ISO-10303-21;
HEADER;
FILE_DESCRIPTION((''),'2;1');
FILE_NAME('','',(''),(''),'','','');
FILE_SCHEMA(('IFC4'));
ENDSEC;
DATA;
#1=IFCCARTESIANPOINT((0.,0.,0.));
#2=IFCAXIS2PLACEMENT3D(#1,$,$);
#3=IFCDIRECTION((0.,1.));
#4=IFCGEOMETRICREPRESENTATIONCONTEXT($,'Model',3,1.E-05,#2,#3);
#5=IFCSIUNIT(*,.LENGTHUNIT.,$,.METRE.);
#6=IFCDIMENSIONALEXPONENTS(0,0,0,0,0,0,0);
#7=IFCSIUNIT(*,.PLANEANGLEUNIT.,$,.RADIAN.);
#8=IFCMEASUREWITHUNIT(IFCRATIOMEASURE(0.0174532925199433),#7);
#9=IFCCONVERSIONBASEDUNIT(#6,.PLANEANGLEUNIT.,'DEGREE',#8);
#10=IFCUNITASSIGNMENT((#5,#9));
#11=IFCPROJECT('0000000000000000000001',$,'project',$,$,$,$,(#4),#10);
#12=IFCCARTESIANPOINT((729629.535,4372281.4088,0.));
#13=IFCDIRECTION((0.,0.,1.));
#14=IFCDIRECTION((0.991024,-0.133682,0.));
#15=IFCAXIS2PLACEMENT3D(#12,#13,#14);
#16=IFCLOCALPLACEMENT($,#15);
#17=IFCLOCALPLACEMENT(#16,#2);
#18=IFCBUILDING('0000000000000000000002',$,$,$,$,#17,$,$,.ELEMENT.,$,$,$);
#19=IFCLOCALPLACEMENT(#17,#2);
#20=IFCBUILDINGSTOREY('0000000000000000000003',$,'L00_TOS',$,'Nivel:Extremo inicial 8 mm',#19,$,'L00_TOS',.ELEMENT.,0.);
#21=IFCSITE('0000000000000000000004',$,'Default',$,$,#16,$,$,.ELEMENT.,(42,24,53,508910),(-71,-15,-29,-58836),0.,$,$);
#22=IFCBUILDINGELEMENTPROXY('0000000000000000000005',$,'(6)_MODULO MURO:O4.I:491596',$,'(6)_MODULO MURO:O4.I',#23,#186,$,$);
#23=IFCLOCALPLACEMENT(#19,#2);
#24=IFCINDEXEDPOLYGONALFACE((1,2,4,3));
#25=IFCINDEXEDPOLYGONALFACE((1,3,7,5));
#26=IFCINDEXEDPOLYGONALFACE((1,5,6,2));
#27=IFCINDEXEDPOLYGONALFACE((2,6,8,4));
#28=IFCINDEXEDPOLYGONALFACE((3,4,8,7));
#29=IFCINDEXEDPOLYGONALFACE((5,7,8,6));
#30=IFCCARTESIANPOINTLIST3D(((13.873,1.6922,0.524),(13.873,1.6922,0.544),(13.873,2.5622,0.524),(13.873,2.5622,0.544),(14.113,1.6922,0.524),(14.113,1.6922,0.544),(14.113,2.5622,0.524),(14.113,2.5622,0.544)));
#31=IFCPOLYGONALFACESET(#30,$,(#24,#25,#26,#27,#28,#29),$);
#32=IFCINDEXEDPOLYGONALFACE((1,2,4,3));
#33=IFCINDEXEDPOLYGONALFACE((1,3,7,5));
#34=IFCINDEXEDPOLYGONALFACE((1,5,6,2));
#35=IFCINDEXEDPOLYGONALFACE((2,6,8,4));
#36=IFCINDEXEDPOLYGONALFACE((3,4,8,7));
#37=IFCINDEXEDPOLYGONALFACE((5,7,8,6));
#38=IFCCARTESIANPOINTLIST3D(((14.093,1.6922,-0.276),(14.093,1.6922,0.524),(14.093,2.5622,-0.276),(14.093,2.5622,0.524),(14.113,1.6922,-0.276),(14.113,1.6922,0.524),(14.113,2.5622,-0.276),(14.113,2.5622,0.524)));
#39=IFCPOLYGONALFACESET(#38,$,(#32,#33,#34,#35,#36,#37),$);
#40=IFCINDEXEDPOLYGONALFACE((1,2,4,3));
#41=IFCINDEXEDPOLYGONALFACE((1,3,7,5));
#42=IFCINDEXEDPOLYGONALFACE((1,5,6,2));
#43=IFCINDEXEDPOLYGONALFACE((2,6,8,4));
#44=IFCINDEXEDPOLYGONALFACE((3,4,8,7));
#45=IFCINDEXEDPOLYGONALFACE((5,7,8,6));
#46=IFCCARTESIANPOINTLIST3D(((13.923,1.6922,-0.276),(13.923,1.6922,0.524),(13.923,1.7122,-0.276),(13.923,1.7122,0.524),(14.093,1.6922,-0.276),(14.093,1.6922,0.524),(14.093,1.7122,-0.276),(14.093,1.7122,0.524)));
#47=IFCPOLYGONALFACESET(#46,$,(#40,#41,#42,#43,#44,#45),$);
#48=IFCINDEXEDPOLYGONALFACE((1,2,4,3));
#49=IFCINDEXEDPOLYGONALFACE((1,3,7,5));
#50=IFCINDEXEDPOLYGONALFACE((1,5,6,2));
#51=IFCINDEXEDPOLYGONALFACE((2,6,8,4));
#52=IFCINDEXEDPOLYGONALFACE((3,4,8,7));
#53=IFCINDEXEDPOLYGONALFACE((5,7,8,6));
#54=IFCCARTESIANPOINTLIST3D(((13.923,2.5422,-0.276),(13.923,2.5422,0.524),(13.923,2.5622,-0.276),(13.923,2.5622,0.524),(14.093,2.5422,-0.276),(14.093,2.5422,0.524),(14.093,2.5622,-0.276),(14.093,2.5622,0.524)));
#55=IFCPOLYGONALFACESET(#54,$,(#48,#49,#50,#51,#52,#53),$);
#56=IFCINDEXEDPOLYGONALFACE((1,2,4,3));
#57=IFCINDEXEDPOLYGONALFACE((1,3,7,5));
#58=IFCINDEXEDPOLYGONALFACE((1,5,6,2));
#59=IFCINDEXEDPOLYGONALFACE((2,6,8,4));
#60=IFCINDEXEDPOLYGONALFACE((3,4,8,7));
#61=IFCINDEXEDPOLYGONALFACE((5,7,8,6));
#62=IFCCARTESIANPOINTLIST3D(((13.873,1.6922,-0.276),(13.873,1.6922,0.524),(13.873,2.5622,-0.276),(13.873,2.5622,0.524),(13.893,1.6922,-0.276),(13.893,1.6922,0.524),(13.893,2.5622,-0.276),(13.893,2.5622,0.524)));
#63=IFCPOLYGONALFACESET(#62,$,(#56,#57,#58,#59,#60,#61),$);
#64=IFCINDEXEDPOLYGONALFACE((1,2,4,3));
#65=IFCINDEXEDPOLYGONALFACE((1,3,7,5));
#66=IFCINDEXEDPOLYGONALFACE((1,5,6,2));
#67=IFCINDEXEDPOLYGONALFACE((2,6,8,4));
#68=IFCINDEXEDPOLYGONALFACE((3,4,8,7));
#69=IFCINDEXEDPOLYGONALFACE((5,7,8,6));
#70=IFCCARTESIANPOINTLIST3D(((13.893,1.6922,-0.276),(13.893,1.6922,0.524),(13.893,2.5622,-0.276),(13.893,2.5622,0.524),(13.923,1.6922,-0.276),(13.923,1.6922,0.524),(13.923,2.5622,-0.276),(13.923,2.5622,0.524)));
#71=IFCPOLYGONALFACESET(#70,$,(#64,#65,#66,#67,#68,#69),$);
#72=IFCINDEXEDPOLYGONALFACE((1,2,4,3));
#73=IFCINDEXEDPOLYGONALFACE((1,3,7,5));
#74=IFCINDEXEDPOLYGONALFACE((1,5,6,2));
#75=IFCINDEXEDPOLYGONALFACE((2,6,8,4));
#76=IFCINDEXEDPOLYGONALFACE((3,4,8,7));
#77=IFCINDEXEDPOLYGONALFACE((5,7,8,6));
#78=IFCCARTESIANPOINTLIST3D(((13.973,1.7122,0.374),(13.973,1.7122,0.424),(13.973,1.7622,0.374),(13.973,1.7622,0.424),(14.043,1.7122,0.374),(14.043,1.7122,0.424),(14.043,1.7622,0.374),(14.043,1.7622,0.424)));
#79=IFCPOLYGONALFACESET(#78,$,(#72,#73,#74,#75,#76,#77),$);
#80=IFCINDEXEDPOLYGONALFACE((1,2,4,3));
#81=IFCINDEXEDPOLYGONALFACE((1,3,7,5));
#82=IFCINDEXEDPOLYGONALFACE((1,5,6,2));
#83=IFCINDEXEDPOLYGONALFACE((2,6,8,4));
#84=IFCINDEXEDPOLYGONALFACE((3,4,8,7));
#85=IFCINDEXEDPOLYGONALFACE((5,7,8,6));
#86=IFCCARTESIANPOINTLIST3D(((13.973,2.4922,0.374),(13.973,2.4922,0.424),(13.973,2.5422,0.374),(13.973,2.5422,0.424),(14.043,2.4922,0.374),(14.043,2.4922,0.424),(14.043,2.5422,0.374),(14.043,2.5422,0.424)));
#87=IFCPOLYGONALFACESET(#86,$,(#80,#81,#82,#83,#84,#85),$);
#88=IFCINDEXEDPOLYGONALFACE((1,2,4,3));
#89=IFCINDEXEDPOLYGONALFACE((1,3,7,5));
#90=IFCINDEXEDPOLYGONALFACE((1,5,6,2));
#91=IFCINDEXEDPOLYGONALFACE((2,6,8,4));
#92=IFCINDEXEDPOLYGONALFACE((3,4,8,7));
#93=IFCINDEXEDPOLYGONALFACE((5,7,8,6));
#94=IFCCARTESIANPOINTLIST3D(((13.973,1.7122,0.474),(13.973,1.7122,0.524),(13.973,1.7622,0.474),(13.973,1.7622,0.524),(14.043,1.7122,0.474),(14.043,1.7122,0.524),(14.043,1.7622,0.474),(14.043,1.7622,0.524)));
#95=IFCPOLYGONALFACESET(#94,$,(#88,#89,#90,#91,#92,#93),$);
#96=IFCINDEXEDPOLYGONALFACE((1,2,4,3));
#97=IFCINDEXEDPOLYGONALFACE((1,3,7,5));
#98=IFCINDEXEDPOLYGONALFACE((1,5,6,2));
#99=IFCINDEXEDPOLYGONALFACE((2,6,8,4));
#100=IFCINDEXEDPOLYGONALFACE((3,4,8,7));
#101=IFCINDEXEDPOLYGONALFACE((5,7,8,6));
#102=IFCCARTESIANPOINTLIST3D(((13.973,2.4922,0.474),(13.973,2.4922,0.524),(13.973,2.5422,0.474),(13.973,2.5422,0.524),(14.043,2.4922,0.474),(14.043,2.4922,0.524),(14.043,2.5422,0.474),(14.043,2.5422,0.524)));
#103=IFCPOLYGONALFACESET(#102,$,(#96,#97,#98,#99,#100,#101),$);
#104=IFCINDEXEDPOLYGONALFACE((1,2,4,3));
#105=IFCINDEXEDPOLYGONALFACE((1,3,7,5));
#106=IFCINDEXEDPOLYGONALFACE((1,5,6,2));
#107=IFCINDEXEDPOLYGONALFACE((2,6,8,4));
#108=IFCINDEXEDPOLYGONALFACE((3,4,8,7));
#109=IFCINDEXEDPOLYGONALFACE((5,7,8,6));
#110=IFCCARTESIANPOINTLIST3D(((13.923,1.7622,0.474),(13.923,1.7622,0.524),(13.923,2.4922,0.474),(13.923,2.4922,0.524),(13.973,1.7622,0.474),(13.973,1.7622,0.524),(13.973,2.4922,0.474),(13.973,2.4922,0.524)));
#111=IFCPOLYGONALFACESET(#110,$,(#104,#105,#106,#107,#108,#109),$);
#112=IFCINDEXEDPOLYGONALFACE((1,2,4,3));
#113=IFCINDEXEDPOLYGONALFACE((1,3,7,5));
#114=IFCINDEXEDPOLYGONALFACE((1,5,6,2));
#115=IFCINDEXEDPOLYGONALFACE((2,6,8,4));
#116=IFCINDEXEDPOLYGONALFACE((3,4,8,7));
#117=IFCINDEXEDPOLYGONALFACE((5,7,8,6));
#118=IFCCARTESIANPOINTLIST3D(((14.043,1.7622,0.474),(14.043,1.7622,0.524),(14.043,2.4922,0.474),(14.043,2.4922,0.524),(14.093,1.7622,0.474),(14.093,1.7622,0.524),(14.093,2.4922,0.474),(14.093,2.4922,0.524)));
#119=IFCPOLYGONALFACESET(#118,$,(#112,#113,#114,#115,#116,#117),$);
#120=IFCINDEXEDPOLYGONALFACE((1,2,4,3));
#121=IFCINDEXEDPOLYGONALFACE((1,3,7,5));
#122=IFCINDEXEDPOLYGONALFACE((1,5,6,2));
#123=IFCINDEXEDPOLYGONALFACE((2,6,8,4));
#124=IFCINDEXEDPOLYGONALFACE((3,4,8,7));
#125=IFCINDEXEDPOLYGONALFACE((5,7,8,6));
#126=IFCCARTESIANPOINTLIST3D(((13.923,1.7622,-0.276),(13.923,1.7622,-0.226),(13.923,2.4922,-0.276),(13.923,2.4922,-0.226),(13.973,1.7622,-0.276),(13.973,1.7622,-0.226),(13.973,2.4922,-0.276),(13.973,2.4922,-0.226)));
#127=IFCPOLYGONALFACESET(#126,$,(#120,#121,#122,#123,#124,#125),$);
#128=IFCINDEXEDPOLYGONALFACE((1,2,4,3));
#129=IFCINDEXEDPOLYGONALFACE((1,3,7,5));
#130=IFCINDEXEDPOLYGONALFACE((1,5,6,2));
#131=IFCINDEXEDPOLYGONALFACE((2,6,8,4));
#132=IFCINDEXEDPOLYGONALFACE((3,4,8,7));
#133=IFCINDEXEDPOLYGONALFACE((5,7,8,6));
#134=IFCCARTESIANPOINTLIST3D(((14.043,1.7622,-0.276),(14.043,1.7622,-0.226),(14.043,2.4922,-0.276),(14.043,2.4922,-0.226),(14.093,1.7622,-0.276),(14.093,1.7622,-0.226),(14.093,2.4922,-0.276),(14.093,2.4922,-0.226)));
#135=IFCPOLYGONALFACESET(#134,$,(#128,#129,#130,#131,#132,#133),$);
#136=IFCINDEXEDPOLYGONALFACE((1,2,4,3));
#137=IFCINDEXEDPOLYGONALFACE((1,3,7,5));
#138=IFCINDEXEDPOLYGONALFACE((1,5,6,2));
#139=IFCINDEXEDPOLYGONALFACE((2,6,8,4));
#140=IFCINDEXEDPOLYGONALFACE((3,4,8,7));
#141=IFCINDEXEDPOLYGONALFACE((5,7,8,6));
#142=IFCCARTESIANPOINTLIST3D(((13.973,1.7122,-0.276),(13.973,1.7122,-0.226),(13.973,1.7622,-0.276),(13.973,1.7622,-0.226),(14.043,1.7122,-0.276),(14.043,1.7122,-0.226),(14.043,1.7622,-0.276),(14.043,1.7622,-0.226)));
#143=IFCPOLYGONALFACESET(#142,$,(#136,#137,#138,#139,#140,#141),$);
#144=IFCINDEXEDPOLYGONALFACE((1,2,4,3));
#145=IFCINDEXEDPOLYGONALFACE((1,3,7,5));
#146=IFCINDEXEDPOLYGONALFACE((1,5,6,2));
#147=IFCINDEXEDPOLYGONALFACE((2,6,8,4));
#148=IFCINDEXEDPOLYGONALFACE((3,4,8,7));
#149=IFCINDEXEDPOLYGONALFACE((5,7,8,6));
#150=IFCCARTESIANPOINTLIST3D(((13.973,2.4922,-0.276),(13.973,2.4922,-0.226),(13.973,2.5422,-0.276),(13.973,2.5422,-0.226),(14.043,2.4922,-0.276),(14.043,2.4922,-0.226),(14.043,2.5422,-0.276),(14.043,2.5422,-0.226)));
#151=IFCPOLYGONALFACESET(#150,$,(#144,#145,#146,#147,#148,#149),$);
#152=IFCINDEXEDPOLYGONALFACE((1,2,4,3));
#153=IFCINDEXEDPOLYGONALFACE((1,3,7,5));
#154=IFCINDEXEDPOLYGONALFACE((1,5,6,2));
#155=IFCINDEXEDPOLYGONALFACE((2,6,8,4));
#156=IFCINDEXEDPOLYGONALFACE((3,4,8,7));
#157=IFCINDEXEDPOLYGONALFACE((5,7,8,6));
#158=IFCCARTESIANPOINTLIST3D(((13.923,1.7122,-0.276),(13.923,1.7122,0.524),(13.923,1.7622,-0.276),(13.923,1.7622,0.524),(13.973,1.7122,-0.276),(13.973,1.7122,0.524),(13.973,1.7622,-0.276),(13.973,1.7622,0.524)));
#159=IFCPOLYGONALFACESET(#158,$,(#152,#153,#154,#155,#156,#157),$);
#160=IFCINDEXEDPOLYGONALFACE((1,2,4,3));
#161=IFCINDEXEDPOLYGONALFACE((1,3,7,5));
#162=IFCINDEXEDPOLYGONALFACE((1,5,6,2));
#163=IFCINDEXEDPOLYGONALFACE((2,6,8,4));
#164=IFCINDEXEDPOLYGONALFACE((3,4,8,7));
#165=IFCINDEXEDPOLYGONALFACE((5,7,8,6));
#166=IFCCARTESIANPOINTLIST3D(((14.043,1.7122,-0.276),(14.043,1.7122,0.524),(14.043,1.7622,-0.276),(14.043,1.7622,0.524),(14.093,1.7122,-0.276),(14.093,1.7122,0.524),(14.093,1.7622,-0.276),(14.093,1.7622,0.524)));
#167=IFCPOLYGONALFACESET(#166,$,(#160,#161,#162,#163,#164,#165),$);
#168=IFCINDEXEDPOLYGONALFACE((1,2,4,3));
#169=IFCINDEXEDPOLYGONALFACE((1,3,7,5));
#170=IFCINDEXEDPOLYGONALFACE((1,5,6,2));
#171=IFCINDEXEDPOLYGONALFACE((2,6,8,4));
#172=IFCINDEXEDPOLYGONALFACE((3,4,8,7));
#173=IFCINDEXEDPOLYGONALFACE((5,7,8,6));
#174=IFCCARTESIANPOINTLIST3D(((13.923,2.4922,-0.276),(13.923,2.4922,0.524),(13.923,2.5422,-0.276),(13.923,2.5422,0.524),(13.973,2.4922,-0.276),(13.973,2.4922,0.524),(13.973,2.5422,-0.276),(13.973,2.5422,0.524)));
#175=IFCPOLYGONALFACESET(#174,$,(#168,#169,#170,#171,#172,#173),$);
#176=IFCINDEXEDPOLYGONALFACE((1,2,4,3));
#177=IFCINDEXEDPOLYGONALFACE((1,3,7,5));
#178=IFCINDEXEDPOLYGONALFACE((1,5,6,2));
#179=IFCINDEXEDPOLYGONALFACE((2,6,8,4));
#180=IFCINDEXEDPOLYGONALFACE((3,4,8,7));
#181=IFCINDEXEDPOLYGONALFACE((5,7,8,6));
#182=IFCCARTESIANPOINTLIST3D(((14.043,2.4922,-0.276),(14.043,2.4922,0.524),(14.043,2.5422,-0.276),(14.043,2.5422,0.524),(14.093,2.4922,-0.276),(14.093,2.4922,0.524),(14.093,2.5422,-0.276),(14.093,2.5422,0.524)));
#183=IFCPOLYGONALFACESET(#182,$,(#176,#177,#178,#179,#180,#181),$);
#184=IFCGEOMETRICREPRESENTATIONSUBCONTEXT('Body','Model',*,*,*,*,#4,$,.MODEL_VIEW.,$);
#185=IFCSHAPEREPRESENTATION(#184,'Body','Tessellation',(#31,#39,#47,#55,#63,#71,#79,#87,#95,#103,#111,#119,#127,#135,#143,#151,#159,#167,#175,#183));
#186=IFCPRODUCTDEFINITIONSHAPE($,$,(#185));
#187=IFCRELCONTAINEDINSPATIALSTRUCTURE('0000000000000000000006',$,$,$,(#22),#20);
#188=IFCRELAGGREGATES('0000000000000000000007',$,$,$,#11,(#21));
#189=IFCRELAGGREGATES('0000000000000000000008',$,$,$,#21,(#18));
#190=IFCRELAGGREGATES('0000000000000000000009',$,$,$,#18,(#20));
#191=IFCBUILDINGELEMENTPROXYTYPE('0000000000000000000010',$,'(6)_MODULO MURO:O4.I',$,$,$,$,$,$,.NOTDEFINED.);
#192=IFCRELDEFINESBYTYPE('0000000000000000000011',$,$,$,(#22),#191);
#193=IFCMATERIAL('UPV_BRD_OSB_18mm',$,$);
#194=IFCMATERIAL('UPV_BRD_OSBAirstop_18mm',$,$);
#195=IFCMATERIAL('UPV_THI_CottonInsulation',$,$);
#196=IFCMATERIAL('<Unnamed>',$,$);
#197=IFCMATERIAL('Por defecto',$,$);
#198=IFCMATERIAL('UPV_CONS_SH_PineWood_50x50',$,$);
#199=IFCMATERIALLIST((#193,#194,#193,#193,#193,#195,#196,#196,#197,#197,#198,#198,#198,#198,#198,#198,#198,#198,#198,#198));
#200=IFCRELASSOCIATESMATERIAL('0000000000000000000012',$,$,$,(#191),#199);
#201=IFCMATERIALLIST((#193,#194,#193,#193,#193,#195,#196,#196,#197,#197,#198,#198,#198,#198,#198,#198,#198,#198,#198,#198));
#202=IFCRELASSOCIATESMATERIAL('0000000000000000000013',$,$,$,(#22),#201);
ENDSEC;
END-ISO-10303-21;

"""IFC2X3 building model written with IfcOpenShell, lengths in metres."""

from ifc_helpers import new_model, entity, si_unit, converted_unit, direction, frame, frame_2d, origin, origin_2d_with_axis, place, context, subcontext, project, spatial, rectangle, extrude, source, transform, mapped, material, material_list, type_object, type_shapes, element, save


model = new_model("IFC2X3")

# Units and contexts
model_context = context("Model", 3, precision=1e-05, world=origin(), true_north=direction((0.0, 1.0)))
body_context = subcontext(model_context, "Body", "Model", "MODEL_VIEW")
ifc_project = project(units=[si_unit("LENGTHUNIT", "METRE"), converted_unit("PLANEANGLEUNIT", "DEGREE", entity("IfcRatioMeasure", 0.0174532925199433), si_unit("PLANEANGLEUNIT", "RADIAN"), dimensions=[0, 0, 0, 0, 0, 0, 0])], contexts=[model_context])

# Site, building, storey
site_placement = place(None, frame((729629.535, 4372281.4088, 0.0), z_axis=(0.0, 0.0, 1.0), x_axis=(0.991024, -0.133682, 0.0)))
site = spatial("IfcSite", under=ifc_project, at=site_placement, Name="Default", CompositionType="ELEMENT", RefLatitude=(42, 24, 53, 508910), RefLongitude=(-71, -15, -29, -58836), RefElevation=0.0)
building_placement = place(site_placement, origin())
building = spatial("IfcBuilding", under=site, at=building_placement, CompositionType="ELEMENT")
storey_placement = place(building_placement, origin())
storey = spatial("IfcBuildingStorey", under=building, at=storey_placement, Name="L00_TOS", ObjectType="Nivel:Extremo inicial 8 mm", LongName="L00_TOS", CompositionType="ELEMENT", Elevation=0.0)

# Building element proxy
ifc_material_1 = material(Name="UPV_BRD_OSBAirstop_18mm")
ifc_material_2 = material(Name="UPV_BRD_OSB_18mm")
ifc_material_3 = material(Name="UPV_THI_CottonInsulation")
ifc_material_4 = material(Name="<Unnamed>")
ifc_material_5 = material(Name="UPV_CONS_SH_PineWood_50x50")
ifc_material_6 = material(Name="Por defecto")
ifc_material_list_1 = material_list([ifc_material_2, ifc_material_1, ifc_material_2, ifc_material_2, ifc_material_2, ifc_material_3, ifc_material_4, ifc_material_4, ifc_material_6, ifc_material_6, ifc_material_5, ifc_material_5, ifc_material_5, ifc_material_5, ifc_material_5, ifc_material_5, ifc_material_5, ifc_material_5, ifc_material_5, ifc_material_5])
ifc_material_list_2 = material_list([ifc_material_2, ifc_material_1, ifc_material_2, ifc_material_2, ifc_material_2, ifc_material_3, ifc_material_4, ifc_material_4, ifc_material_6, ifc_material_6, ifc_material_5, ifc_material_5, ifc_material_5, ifc_material_5, ifc_material_5, ifc_material_5, ifc_material_5, ifc_material_5, ifc_material_5, ifc_material_5])
building_element_proxy_type_1 = type_object("IfcBuildingElementProxyType", Name="(6)_MODULO MURO:O4.I", PredefinedType="NOTDEFINED", material=ifc_material_list_2)
shared_shape_1 = source(origin(), body_context, "Body", "SweptSolid", [
    extrude(rectangle(XDim=0.87, YDim=0.24, at=origin_2d_with_axis()), frame((0.0, 0.015, 0.8), z_axis=(0.0, 0.0, 1.0), x_axis=(-1.0, 0.0, 0.0)), (0.0, 0.0, 1.0), 0.02),
    extrude(rectangle(XDim=0.87, YDim=0.02, at=origin_2d_with_axis()), frame((0.0, -0.095, 0.0)), (0.0, 0.0, 1.0), 0.8),
    extrude(rectangle(XDim=0.17, YDim=0.02, at=frame_2d((0.0, 0.0), x_axis=(1.0, 0.0))), frame((-0.425, 0.0, 0.0), z_axis=(0.0, 0.0, 1.0), x_axis=(0.0, -1.0, 0.0)), (0.0, 0.0, 1.0), 0.8),
    extrude(rectangle(XDim=0.17, YDim=0.02, at=origin_2d_with_axis()), frame((0.425, 0.0, 0.0), z_axis=(0.0, 0.0, 1.0), x_axis=(0.0, -1.0, 0.0)), (0.0, 0.0, 1.0), 0.8),
    extrude(rectangle(XDim=0.87, YDim=0.02, at=origin_2d_with_axis()), frame((0.0, 0.125, 0.0), z_axis=(0.0, 0.0, 1.0), x_axis=(-1.0, 0.0, 0.0)), (0.0, 0.0, 1.0), 0.8),
    extrude(rectangle(XDim=0.87, YDim=0.03, at=origin_2d_with_axis()), frame((0.0, 0.1, 0.0), z_axis=(0.0, 0.0, 1.0), x_axis=(-1.0, 0.0, 0.0)), (0.0, 0.0, 1.0), 0.8),
    extrude(rectangle(XDim=0.07, YDim=0.05, at=origin_2d_with_axis()), frame((-0.39, 0.0, 0.65), z_axis=(0.0, 0.0, 1.0), x_axis=(0.0, 1.0, 0.0)), (0.0, 0.0, 1.0), 0.05),
    extrude(rectangle(XDim=0.07, YDim=0.05, at=origin_2d_with_axis()), frame((0.39, 0.0, 0.65), z_axis=(0.0, 0.0, 1.0), x_axis=(0.0, 1.0, 0.0)), (0.0, 0.0, 1.0), 0.05),
    extrude(rectangle(XDim=0.07, YDim=0.05, at=origin_2d_with_axis()), frame((-0.39, 0.0, 0.75), z_axis=(0.0, 0.0, 1.0), x_axis=(0.0, -1.0, 0.0)), (0.0, 0.0, 1.0), 0.05),
    extrude(rectangle(XDim=0.07, YDim=0.05, at=frame_2d((0.0, 0.0), x_axis=(1.0, 0.0))), frame((0.39, 0.0, 0.75), z_axis=(0.0, 0.0, 1.0), x_axis=(0.0, -1.0, 0.0)), (0.0, 0.0, 1.0), 0.05),
    extrude(rectangle(XDim=0.73, YDim=0.05, at=origin_2d_with_axis()), frame((0.0, 0.06, 0.75), z_axis=(0.0, 0.0, 1.0), x_axis=(-1.0, 0.0, 0.0)), (0.0, 0.0, 1.0), 0.05),
    extrude(rectangle(XDim=0.05, YDim=0.73, at=origin_2d_with_axis()), frame((0.0, -0.06, 0.75), z_axis=(0.0, 0.0, 1.0), x_axis=(0.0, -1.0, 0.0)), (0.0, 0.0, 1.0), 0.05),
    extrude(rectangle(XDim=0.05, YDim=0.73, at=origin_2d_with_axis()), frame((0.0, 0.06, 0.0), z_axis=(0.0, 0.0, 1.0), x_axis=(0.0, -1.0, 0.0)), (0.0, 0.0, 1.0), 0.05),
    extrude(rectangle(XDim=0.05, YDim=0.73, at=origin_2d_with_axis()), frame((0.0, -0.06, 0.0), z_axis=(0.0, 0.0, 1.0), x_axis=(0.0, -1.0, 0.0)), (0.0, 0.0, 1.0), 0.05),
    extrude(rectangle(XDim=0.07, YDim=0.05, at=origin_2d_with_axis()), frame((-0.39, 0.0, 0.0), z_axis=(0.0, 0.0, 1.0), x_axis=(0.0, -1.0, 0.0)), (0.0, 0.0, 1.0), 0.05),
    extrude(rectangle(XDim=0.05, YDim=0.07, at=origin_2d_with_axis()), frame((0.39, 0.0, 0.0), z_axis=(0.0, 0.0, 1.0), x_axis=(-1.0, 0.0, 0.0)), (0.0, 0.0, 1.0), 0.05),
    extrude(rectangle(XDim=0.05, YDim=0.05, at=origin_2d_with_axis()), frame((-0.39, 0.06, 0.0), z_axis=(0.0, 0.0, 1.0), x_axis=(0.0, -1.0, 0.0)), (0.0, 0.0, 1.0), 0.8),
    extrude(rectangle(XDim=0.05, YDim=0.05, at=origin_2d_with_axis()), frame((-0.39, -0.06, 0.0), z_axis=(0.0, 0.0, 1.0), x_axis=(0.0, -1.0, 0.0)), (0.0, 0.0, 1.0), 0.8),
    extrude(rectangle(XDim=0.05, YDim=0.05, at=origin_2d_with_axis()), frame((0.39, 0.06, 0.0), z_axis=(0.0, 0.0, 1.0), x_axis=(0.0, -1.0, 0.0)), (0.0, 0.0, 1.0), 0.8),
    extrude(rectangle(XDim=0.05, YDim=0.05, at=origin_2d_with_axis()), frame((0.39, -0.06, 0.0), z_axis=(0.0, 0.0, 1.0), x_axis=(0.0, -1.0, 0.0)), (0.0, 0.0, 1.0), 0.8),
])
type_shapes(building_element_proxy_type_1, [shared_shape_1])
proxy_1_placement = place(storey_placement, frame((14.008, 2.1272, -0.276), z_axis=(0.0, 0.0, 1.0), x_axis=(0.0, 1.0, 0.0)))
element("IfcBuildingElementProxy", 1, at=proxy_1_placement, inside=storey, type_object=building_element_proxy_type_1, material=ifc_material_list_1, Name="(6)_MODULO MURO:O4.I:491596", ObjectType="(6)_MODULO MURO:O4.I", context=body_context, shape_type="MappedRepresentation", body=[
    mapped(shared_shape_1, transform((0.0, 0.0, 0.0), scale=1.0)),
])

save(model, "model.ifc")
